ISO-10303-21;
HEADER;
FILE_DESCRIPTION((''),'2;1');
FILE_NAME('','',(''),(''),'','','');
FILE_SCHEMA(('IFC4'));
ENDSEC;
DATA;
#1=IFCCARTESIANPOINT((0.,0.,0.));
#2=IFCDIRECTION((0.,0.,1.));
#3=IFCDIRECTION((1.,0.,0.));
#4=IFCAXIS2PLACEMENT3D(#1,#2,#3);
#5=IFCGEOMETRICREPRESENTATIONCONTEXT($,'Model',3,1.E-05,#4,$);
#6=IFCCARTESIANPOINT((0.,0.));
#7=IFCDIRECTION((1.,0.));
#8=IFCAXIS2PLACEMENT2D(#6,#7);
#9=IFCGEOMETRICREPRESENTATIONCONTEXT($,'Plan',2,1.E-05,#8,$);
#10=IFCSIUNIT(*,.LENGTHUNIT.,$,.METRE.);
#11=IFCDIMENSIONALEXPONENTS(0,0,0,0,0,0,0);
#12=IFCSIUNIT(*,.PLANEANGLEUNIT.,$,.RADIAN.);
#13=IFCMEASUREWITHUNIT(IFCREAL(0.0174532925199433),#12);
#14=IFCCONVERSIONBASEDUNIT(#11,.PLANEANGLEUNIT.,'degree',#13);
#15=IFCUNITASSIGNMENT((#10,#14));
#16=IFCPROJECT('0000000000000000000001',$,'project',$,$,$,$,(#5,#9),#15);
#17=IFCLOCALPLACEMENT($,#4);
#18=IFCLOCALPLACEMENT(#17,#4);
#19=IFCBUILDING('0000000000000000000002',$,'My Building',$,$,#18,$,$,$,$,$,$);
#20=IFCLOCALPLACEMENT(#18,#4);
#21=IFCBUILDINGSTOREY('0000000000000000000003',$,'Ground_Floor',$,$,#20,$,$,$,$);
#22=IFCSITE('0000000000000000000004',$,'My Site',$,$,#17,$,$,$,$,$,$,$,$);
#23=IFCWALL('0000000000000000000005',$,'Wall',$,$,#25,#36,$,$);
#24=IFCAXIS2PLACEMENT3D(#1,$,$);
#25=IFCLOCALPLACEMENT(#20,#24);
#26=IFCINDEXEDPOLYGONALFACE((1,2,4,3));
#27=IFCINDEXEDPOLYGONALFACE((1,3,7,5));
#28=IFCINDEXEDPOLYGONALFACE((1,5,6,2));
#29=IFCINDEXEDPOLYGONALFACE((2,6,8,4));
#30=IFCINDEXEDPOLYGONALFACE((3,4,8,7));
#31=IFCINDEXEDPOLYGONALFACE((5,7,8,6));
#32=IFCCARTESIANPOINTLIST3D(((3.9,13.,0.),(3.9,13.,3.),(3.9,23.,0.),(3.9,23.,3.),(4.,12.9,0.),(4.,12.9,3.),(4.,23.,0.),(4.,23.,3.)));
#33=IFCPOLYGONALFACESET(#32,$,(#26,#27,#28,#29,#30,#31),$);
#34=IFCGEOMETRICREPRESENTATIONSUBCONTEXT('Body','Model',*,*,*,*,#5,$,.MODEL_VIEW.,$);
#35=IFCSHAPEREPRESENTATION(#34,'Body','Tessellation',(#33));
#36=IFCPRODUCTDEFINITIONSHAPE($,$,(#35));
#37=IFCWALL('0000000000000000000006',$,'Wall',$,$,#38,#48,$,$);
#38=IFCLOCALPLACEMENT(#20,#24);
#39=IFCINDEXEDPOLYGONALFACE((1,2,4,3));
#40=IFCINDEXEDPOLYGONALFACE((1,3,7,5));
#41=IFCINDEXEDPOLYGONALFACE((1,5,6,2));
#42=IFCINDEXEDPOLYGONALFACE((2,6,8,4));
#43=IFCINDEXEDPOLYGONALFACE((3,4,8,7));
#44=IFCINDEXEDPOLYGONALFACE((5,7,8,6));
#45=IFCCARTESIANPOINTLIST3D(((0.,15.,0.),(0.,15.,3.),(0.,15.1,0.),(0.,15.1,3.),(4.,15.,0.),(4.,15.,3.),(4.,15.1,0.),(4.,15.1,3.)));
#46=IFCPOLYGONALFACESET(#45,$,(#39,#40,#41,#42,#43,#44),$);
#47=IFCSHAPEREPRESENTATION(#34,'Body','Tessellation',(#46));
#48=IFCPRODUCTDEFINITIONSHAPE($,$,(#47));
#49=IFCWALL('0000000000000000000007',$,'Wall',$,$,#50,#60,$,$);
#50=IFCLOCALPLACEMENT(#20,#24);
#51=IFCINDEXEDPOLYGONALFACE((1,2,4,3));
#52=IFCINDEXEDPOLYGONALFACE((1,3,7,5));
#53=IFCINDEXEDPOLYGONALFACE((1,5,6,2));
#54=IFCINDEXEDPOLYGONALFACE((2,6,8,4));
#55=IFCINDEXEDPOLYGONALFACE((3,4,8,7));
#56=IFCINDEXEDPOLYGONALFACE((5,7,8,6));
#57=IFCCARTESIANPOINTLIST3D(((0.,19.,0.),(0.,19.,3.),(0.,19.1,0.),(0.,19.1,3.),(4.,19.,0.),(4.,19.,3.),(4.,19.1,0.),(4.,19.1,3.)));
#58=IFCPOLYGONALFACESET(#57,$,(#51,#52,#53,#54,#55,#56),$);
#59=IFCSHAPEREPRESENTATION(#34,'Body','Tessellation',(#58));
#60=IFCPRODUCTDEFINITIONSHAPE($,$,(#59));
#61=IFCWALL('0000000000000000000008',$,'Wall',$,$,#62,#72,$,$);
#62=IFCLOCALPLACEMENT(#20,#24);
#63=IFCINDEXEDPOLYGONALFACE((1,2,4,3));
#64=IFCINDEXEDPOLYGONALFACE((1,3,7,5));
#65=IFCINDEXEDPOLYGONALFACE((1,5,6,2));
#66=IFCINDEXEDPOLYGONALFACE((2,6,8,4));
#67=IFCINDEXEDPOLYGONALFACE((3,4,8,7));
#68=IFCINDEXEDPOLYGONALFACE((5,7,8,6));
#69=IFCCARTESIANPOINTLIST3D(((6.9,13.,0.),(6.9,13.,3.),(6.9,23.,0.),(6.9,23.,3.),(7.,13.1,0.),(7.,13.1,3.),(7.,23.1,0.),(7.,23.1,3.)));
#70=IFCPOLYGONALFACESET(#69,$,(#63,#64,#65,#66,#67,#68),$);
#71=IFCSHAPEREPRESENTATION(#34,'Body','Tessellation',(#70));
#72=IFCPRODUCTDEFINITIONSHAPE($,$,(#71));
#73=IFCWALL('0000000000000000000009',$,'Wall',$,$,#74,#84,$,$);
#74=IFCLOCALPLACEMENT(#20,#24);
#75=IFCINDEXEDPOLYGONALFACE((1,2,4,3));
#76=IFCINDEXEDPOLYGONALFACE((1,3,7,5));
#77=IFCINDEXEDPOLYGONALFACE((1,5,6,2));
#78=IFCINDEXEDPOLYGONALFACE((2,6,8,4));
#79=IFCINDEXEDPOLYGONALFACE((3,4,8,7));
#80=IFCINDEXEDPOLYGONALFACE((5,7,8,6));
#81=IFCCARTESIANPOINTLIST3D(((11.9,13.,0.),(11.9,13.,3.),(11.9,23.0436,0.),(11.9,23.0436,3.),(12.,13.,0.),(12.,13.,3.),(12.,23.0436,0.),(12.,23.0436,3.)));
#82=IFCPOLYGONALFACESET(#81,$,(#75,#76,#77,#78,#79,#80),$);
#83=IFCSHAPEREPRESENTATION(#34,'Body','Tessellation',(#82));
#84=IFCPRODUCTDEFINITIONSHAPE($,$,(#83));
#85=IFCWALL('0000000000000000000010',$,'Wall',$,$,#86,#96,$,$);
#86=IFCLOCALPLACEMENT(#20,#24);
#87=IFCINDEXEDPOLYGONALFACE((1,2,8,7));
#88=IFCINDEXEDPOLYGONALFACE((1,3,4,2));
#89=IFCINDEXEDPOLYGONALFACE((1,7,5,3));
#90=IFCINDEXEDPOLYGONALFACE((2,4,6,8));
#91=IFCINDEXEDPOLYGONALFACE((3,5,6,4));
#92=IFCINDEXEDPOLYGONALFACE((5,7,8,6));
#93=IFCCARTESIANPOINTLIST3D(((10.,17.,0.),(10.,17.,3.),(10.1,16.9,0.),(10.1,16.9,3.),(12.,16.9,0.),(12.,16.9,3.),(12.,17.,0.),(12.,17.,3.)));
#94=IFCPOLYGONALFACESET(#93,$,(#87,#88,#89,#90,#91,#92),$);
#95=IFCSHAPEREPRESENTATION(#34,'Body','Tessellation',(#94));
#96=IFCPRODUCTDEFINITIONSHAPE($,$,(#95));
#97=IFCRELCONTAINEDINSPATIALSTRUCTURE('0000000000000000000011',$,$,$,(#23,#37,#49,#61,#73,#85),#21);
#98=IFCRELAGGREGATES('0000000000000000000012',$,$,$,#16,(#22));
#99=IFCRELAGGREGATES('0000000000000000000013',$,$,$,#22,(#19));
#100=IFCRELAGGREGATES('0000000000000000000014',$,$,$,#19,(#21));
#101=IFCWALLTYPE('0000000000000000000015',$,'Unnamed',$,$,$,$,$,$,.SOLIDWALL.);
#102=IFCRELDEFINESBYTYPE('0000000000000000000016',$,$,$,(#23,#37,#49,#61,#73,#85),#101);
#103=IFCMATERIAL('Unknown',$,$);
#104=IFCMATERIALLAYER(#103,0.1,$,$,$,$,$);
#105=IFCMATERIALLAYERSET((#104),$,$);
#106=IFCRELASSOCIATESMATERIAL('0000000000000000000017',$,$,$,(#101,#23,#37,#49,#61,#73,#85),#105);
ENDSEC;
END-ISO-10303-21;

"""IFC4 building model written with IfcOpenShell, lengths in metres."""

from ifc_helpers import new_model, entity, si_unit, converted_unit, frame, origin_with_axes, origin_2d_with_axis, place, context, subcontext, project, spatial, line, indexed_curve, outline, extrude, material, layer, layer_set, layer_usage, type_object, element, save


model = new_model("IFC4")

# Units and contexts
model_context = context("Model", 3, precision=1e-05, world=origin_with_axes())
plan_context = context("Plan", 2, precision=1e-05, world=origin_2d_with_axis())
body_context_1 = subcontext(model_context, "Body", "Model", "MODEL_VIEW")
ifc_project = project(units=[si_unit("LENGTHUNIT", "METRE"), converted_unit("PLANEANGLEUNIT", "degree", entity("IfcReal", 0.0174532925199433), si_unit("PLANEANGLEUNIT", "RADIAN"), dimensions=[0, 0, 0, 0, 0, 0, 0])], contexts=[model_context, plan_context])

# Site, building, storey
site_placement = place(None, origin_with_axes())
site = spatial("IfcSite", under=ifc_project, at=site_placement, Name="My Site")
building_placement = place(site_placement, origin_with_axes())
building = spatial("IfcBuilding", under=site, at=building_placement, Name="My Building")
storey_placement = place(building_placement, origin_with_axes())
storey = spatial("IfcBuildingStorey", under=building, at=storey_placement, Name="Ground_Floor")

# Shared definitions
ifc_material = material(Name="Unknown")

# Wall
ifc_layer_1 = layer(ifc_material, 0.1)
ifc_layer_set_1 = layer_set([ifc_layer_1])
ifc_layer_usage_1 = layer_usage(ifc_layer_set_1, "AXIS2", "POSITIVE", 0.0)
wall_type = type_object("IfcWallType", Name="Unnamed", PredefinedType="SOLIDWALL", material=ifc_layer_set_1)
wall_1_placement = place(storey_placement, frame((4.0, 13.0, 0.0), z_axis=(0.0, 0.0, 1.0), x_axis=(0.0, 1.0, 0.0)))
element("IfcWall", 1, at=wall_1_placement, inside=storey, type_object=wall_type, material=ifc_layer_usage_1, Name="Wall", context=body_context_1, shape_type="SweptSolid", body=[
    extrude(outline(indexed_curve([(-0.1, 0.0), (0.0, 0.1), (10.0, 0.1), (10.0, 0.0)], segments=[line(1, 2, 3, 4, 1)])), origin_with_axes(), (0.0, 0.0, 1.0), 3.0),
])

# Walls
ifc_layer_usage_2 = layer_usage(ifc_layer_set_1, "AXIS2", "POSITIVE", 0.0)
wall_2_placement = place(storey_placement, frame((0.0, 15.0, 0.0), z_axis=(0.0, 0.0, 1.0), x_axis=(1.0, 0.0, 0.0)))
element("IfcWall", 2, at=wall_2_placement, inside=storey, type_object=wall_type, material=ifc_layer_usage_2, Name="Wall", context=body_context_1, shape_type="SweptSolid", body=[
    extrude(outline(indexed_curve([(0.0, 0.0), (0.0, 0.1), (4.0, 0.1), (4.0, 0.0)], segments=[line(1, 2, 3, 4, 1)])), origin_with_axes(), (0.0, 0.0, 1.0), 3.0),
])
ifc_layer_usage_3 = layer_usage(ifc_layer_set_1, "AXIS2", "POSITIVE", 0.0)
wall_3_placement = place(storey_placement, frame((0.0, 19.0, 0.0), z_axis=(0.0, 0.0, 1.0), x_axis=(1.0, 0.0, 0.0)))
element("IfcWall", 3, at=wall_3_placement, inside=storey, type_object=wall_type, material=ifc_layer_usage_3, Name="Wall", context=body_context_1, shape_type="SweptSolid", body=[
    extrude(outline(indexed_curve([(0.0, 0.0), (0.0, 0.1), (4.0, 0.1), (4.0, 0.0)], segments=[line(1, 2, 3, 4, 1)])), origin_with_axes(), (0.0, 0.0, 1.0), 3.0),
])
ifc_layer_usage_4 = layer_usage(ifc_layer_set_1, "AXIS2", "POSITIVE", 0.0)
wall_4_placement = place(storey_placement, frame((7.0, 13.0, 0.0), z_axis=(0.0, 0.0, 1.0), x_axis=(0.0, 1.0, 0.0)))
element("IfcWall", 4, at=wall_4_placement, inside=storey, type_object=wall_type, material=ifc_layer_usage_4, Name="Wall", context=body_context_1, shape_type="SweptSolid", body=[
    extrude(outline(indexed_curve([(0.1, 0.0), (0.0, 0.1), (10.0, 0.1), (10.1, 0.0)], segments=[line(1, 2, 3, 4, 1)])), origin_with_axes(), (0.0, 0.0, 1.0), 3.0),
])
ifc_layer_usage_5 = layer_usage(ifc_layer_set_1, "AXIS2", "POSITIVE", 0.0)
wall_5_placement = place(storey_placement, frame((12.0, 13.0, 0.0), z_axis=(0.0, 0.0, 1.0), x_axis=(0.0, 1.0, 0.0)))
element("IfcWall", 5, at=wall_5_placement, inside=storey, type_object=wall_type, material=ifc_layer_usage_5, Name="Wall", context=body_context_1, shape_type="SweptSolid", body=[
    extrude(outline(indexed_curve([(0.0, 0.0), (0.0, 0.1), (10.0436, 0.1), (10.0436, 0.0)], segments=[line(1, 2, 3, 4, 1)])), origin_with_axes(), (0.0, 0.0, 1.0), 3.0),
])
ifc_layer_usage_6 = layer_usage(ifc_layer_set_1, "AXIS2", "POSITIVE", 0.0)
wall_6_placement = place(storey_placement, frame((12.0, 17.0, 0.0), z_axis=(0.0, 0.0, 1.0), x_axis=(-1.0, 0.0, 0.0)))
element("IfcWall", 6, at=wall_6_placement, inside=storey, type_object=wall_type, material=ifc_layer_usage_6, Name="Wall", context=body_context_1, shape_type="SweptSolid", body=[
    extrude(outline(indexed_curve([(0.0, 0.0), (0.0, 0.1), (1.9, 0.1), (2.0, 0.0)], segments=[line(1, 2, 3, 4, 1)])), origin_with_axes(), (0.0, 0.0, 1.0), 3.0),
])

save(model, "model.ifc")
